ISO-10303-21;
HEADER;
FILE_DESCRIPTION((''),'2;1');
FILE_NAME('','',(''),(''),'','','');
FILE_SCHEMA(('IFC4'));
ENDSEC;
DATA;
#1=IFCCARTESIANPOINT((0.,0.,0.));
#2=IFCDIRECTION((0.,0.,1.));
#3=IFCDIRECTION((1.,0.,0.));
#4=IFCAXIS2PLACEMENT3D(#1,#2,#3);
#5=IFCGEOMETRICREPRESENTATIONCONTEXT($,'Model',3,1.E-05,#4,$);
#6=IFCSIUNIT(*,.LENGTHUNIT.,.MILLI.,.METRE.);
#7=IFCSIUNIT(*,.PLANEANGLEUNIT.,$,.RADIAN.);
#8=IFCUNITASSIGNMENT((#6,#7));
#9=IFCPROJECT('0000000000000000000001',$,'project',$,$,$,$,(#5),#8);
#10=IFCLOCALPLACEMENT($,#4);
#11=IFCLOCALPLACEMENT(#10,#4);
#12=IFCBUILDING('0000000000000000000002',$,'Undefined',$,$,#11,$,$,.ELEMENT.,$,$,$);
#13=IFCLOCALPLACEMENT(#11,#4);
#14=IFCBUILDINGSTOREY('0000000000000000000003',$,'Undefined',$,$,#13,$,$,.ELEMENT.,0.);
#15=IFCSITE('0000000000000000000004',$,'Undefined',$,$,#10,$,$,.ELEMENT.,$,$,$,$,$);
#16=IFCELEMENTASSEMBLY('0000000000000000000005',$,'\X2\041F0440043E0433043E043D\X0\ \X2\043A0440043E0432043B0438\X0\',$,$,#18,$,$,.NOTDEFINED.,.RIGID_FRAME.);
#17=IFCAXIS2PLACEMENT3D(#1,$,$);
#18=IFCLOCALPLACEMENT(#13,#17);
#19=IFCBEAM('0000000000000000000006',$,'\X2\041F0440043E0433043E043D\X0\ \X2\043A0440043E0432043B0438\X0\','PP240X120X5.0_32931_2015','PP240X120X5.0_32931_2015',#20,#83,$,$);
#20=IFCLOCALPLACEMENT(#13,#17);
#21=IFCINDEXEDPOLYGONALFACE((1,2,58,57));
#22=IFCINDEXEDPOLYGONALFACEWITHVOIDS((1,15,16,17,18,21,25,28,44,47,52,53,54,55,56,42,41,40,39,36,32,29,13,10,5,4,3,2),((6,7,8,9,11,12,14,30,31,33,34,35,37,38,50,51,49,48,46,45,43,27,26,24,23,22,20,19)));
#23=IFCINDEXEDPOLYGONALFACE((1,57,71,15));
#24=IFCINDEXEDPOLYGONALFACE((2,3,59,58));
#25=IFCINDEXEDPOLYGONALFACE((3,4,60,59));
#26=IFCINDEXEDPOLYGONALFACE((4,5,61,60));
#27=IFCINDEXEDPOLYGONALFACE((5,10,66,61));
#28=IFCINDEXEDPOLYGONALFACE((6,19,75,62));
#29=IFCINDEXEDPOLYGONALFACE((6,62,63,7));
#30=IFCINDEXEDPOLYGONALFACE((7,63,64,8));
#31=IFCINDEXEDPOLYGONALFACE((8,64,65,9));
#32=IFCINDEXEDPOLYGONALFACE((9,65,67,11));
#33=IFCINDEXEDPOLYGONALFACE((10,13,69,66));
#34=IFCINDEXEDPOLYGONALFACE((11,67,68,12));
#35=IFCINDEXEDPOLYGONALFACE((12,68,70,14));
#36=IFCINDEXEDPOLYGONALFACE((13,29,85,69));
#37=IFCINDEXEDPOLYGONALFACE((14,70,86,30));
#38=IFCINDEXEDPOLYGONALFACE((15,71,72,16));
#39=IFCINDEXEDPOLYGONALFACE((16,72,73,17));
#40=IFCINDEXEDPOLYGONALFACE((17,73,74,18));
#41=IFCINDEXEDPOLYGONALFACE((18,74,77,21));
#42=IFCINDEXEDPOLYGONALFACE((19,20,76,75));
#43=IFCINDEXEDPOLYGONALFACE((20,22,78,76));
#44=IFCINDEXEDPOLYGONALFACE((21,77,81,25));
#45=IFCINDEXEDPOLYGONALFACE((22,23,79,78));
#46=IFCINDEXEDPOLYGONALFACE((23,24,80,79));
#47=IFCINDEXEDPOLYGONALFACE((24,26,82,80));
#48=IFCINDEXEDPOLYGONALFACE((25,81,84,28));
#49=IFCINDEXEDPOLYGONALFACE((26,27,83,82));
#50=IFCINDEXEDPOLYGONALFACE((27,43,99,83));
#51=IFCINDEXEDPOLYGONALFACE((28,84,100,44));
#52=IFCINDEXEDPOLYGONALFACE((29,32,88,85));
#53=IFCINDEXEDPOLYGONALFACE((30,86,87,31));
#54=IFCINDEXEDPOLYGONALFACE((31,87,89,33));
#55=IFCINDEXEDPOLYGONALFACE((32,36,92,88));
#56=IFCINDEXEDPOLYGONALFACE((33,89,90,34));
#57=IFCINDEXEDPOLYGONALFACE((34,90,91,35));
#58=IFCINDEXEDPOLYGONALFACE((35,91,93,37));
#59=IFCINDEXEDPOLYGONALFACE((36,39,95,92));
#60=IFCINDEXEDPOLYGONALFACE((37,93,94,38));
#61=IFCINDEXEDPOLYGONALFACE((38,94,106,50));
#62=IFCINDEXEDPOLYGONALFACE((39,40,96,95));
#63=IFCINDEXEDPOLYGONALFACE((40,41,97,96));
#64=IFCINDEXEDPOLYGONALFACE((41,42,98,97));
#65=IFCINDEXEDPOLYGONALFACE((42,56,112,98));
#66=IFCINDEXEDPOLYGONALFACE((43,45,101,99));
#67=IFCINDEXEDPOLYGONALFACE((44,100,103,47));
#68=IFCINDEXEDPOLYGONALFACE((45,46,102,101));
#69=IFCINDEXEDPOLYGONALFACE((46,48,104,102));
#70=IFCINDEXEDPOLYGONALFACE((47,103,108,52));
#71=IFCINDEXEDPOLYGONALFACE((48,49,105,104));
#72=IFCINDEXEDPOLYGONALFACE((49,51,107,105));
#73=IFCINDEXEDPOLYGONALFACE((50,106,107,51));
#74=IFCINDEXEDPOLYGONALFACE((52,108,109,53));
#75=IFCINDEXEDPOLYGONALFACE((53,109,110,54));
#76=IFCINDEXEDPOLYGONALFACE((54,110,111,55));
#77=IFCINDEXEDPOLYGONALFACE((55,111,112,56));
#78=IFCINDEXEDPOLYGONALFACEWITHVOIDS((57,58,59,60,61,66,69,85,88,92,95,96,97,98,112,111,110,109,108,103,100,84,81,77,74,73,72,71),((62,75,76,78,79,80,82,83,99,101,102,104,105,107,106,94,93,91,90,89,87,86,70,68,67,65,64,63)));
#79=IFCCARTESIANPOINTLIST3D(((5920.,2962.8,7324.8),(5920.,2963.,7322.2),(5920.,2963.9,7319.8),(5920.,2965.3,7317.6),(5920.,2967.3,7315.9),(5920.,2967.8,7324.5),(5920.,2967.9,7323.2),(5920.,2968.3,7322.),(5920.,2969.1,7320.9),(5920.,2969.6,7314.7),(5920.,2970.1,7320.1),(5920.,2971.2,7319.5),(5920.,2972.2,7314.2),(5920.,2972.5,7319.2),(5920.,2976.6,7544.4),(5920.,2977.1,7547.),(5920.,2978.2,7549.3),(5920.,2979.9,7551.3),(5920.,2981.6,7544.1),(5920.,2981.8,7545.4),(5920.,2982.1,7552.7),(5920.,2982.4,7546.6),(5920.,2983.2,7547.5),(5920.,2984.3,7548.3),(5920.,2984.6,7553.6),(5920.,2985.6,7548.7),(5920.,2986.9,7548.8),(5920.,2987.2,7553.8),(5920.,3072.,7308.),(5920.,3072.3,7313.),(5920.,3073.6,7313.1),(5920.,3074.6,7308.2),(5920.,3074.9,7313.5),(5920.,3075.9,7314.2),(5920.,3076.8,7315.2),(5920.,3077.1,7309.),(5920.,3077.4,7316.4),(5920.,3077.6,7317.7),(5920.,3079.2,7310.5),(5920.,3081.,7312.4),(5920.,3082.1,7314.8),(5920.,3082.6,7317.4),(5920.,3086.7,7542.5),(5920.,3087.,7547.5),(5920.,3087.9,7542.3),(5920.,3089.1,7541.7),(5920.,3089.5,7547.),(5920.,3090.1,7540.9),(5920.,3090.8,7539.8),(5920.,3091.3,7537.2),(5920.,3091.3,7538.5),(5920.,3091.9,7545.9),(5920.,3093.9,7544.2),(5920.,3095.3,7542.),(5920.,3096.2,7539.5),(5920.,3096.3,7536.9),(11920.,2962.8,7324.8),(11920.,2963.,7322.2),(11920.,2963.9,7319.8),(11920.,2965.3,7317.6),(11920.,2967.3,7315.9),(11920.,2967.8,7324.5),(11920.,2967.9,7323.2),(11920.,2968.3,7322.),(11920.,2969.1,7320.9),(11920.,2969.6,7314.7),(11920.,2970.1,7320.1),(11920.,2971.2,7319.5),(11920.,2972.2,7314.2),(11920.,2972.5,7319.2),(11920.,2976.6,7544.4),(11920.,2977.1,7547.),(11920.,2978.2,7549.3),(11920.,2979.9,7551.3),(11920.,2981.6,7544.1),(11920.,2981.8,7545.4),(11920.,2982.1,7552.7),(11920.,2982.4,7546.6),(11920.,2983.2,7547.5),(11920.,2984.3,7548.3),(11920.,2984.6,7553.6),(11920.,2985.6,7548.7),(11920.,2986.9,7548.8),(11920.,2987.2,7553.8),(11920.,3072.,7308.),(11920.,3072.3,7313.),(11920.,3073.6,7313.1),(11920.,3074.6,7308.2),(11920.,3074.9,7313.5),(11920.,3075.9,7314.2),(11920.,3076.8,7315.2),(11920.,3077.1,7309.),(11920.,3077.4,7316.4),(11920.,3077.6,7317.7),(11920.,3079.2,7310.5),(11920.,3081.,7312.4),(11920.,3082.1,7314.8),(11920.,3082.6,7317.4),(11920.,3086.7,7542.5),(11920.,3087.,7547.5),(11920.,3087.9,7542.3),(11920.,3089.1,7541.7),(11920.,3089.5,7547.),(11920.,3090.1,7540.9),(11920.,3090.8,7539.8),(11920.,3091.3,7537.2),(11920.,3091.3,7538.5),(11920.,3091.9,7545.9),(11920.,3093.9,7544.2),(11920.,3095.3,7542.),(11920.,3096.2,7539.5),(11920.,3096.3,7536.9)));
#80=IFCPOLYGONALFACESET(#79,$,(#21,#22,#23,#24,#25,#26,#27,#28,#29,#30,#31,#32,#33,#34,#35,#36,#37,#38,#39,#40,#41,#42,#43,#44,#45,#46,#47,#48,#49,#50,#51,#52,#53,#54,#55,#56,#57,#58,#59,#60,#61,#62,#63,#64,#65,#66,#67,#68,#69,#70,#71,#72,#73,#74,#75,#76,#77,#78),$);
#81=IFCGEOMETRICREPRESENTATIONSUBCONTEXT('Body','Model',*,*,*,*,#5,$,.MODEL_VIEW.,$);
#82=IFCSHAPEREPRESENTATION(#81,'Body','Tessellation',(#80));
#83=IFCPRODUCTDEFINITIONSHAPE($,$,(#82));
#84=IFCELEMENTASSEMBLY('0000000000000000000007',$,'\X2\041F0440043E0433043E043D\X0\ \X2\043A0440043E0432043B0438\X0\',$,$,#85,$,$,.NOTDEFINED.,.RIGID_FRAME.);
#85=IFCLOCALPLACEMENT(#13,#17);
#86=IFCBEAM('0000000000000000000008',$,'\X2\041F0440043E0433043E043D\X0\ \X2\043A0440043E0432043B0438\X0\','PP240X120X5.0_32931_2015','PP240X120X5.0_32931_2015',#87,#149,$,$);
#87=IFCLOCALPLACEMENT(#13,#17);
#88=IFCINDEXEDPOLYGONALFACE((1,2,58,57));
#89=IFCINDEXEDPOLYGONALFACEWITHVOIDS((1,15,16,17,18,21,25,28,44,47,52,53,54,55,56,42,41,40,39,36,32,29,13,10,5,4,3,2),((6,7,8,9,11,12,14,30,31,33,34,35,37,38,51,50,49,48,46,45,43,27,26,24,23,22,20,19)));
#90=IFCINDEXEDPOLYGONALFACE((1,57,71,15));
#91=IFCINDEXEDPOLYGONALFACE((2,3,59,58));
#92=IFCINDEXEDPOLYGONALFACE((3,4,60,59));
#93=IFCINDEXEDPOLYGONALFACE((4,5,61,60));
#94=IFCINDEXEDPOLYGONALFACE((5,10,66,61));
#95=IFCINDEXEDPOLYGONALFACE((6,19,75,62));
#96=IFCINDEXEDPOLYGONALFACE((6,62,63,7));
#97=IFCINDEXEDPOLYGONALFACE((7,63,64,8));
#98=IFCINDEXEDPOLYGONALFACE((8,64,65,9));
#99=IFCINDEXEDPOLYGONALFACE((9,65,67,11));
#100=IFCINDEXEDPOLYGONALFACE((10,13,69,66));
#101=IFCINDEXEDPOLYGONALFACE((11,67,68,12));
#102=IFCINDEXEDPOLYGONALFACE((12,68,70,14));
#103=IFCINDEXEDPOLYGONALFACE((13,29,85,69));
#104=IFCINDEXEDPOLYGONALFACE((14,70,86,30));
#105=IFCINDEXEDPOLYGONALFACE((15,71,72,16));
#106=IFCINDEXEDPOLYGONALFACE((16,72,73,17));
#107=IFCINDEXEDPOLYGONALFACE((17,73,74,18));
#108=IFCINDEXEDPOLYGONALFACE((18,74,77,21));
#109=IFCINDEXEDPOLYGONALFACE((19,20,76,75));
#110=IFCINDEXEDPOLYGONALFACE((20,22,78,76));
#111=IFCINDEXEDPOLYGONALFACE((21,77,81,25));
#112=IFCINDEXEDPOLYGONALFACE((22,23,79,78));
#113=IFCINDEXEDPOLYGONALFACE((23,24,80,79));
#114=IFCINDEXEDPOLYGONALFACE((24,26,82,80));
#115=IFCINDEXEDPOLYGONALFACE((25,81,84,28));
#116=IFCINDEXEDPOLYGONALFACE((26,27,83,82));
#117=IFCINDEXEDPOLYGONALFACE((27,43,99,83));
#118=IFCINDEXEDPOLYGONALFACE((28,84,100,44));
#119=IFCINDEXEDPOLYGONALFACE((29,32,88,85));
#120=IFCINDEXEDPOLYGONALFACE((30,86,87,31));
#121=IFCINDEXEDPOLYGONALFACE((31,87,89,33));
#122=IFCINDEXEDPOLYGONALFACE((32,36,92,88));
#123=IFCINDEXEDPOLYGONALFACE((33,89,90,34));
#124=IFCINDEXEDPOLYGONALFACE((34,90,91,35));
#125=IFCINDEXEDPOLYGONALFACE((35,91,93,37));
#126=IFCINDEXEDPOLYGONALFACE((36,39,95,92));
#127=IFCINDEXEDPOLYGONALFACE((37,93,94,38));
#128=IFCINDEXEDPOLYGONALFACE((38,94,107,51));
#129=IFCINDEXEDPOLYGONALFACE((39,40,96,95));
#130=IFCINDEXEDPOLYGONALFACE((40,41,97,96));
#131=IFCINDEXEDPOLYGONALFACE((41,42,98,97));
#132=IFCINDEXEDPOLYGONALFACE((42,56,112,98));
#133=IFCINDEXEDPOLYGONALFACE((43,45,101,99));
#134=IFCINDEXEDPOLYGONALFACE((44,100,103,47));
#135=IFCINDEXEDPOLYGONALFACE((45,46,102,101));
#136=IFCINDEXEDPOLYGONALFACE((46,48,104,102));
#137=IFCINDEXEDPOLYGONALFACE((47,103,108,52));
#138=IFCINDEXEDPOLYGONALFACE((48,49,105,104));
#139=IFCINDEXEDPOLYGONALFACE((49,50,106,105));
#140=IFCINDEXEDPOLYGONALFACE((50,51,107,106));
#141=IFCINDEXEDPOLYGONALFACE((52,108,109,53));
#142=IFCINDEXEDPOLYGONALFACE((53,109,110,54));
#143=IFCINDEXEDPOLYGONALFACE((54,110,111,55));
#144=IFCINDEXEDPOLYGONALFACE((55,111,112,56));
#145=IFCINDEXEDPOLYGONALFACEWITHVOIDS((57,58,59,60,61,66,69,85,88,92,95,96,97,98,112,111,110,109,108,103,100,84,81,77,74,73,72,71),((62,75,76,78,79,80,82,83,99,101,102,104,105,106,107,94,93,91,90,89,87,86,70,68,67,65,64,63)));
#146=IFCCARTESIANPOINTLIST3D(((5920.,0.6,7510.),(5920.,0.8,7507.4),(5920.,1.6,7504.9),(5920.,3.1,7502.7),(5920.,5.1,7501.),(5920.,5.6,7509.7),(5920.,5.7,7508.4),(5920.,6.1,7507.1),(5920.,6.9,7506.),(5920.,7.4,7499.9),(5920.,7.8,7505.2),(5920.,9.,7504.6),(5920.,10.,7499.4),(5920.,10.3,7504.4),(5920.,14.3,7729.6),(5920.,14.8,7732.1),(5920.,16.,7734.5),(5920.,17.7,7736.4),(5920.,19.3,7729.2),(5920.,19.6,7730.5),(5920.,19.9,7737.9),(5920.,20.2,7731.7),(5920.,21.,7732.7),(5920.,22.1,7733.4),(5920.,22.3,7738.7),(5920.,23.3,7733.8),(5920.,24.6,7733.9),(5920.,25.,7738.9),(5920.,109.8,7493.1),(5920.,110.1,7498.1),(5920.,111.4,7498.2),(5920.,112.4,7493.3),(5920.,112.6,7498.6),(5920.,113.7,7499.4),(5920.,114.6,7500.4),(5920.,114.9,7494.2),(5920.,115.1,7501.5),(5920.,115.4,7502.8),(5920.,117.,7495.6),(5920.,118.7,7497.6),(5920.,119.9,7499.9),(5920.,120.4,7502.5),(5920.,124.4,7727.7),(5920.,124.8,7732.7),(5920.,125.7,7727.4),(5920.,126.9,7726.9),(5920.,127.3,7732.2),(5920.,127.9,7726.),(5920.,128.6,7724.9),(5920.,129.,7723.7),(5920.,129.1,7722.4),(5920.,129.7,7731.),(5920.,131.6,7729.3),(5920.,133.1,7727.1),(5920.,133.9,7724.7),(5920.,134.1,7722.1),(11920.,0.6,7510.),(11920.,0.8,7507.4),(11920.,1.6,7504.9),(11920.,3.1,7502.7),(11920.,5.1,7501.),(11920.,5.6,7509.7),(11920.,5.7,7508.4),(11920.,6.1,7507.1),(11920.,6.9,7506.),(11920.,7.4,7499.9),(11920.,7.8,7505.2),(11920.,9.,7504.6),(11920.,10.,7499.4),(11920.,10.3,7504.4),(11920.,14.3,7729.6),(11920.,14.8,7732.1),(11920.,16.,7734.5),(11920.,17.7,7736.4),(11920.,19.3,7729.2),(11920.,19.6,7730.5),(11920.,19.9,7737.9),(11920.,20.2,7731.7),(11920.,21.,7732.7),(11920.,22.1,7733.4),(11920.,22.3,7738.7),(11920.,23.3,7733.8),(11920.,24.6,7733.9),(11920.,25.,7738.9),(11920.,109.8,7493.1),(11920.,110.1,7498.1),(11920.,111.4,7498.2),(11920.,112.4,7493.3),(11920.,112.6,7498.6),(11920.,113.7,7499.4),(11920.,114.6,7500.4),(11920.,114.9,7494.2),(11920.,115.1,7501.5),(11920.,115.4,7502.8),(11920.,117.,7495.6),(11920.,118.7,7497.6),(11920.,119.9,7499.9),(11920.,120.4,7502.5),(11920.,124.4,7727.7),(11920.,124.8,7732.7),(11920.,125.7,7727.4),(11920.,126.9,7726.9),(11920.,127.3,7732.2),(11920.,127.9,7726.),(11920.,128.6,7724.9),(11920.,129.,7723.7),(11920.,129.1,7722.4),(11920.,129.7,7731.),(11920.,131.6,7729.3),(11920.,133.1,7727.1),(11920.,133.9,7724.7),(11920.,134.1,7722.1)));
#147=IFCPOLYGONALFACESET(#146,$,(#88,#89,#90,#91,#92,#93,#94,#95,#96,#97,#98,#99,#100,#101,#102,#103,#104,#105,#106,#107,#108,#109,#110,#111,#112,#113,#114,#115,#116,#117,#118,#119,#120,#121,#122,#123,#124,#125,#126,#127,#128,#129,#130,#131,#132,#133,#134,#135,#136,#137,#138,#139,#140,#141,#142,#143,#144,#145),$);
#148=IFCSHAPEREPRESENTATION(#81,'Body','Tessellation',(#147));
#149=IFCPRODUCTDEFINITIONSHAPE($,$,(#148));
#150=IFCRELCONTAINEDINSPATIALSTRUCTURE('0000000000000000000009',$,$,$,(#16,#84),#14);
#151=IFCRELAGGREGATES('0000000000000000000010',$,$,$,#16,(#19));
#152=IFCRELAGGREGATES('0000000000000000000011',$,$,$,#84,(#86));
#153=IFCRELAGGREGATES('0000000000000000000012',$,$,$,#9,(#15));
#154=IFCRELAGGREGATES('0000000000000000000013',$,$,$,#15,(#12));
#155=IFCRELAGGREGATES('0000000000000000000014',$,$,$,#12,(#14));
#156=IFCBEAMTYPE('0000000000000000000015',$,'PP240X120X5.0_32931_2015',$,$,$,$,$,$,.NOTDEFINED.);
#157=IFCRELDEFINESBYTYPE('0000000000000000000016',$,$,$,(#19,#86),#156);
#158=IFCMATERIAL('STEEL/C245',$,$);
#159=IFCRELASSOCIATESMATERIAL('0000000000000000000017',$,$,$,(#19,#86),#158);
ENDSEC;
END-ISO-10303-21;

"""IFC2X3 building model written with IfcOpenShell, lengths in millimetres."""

from ifc_helpers import new_model, si_unit, frame, origin_with_axes, origin_2d_with_axis, place, context, subcontext, project, spatial, hollow_rectangle, extrude, material, type_object, element, aggregate, save


model = new_model("IFC2X3")

# Units and contexts
model_context = context("Model", 3, precision=1e-05, world=origin_with_axes())
body_context = subcontext(model_context, "Body", "Model", "MODEL_VIEW")
ifc_project = project(units=[si_unit("LENGTHUNIT", "METRE", prefix="MILLI"), si_unit("PLANEANGLEUNIT", "RADIAN")], contexts=[model_context])

# Site, building, storey
site_placement = place(None, origin_with_axes())
site = spatial("IfcSite", under=ifc_project, at=site_placement, Name="Undefined", CompositionType="ELEMENT")
building_placement = place(site_placement, origin_with_axes())
building = spatial("IfcBuilding", under=site, at=building_placement, Name="Undefined", CompositionType="ELEMENT")
storey_placement = place(building_placement, origin_with_axes())
storey = spatial("IfcBuildingStorey", under=building, at=storey_placement, Name="Undefined", CompositionType="ELEMENT", Elevation=0.0)

# Shared definitions
ifc_material = material(Name="STEEL/C245")

# Element assemblies, beams
beam_type_1 = type_object("IfcBeamType", Name="PP240X120X5.0_32931_2015", PredefinedType="NOTDEFINED")
assembly_1_placement = place(storey_placement, origin_with_axes())
assembly_1 = element("IfcElementAssembly", 1, at=assembly_1_placement, inside=storey, Name="Прогон кровли", AssemblyPlace="NOTDEFINED", PredefinedType="RIGID_FRAME")
beam_1_placement = place(assembly_1_placement, frame((11920.0, 3029.6, 7430.9), z_axis=(0.0, 0.062378, 0.998053), x_axis=(-1.0, 0.0, 0.0)))
beam_1 = element("IfcBeam", 2, at=beam_1_placement, type_object=beam_type_1, material=ifc_material, Name="Прогон кровли", Description="PP240X120X5.0_32931_2015", ObjectType="PP240X120X5.0_32931_2015", context=body_context, shape_type="SweptSolid", body=[
    extrude(hollow_rectangle(XDim=120.0, YDim=240.0, WallThickness=5.0, InnerFilletRadius=5.0, OuterFilletRadius=10.0, at=origin_2d_with_axis()), frame((6000.0, 0.0, 0.0), z_axis=(-1.0, 0.0, 0.0), x_axis=(0.0, -1.0, 0.0)), (0.0, 0.0, 1.0), 6000.0),
])
aggregate(assembly_1, [beam_1])
assembly_2_placement = place(storey_placement, origin_with_axes())
assembly_2 = element("IfcElementAssembly", 3, at=assembly_2_placement, inside=storey, Name="Прогон кровли", AssemblyPlace="NOTDEFINED", PredefinedType="RIGID_FRAME")
beam_2_placement = place(assembly_2_placement, frame((11920.0, 67.4, 7616.0), z_axis=(0.0, 0.062378, 0.998053), x_axis=(-1.0, 0.0, 0.0)))
beam_2 = element("IfcBeam", 4, at=beam_2_placement, type_object=beam_type_1, material=ifc_material, Name="Прогон кровли", Description="PP240X120X5.0_32931_2015", ObjectType="PP240X120X5.0_32931_2015", context=body_context, shape_type="SweptSolid", body=[
    extrude(hollow_rectangle(XDim=120.0, YDim=240.0, WallThickness=5.0, InnerFilletRadius=5.0, OuterFilletRadius=10.0, at=origin_2d_with_axis()), frame((6000.0, 0.0, 0.0), z_axis=(-1.0, 0.0, 0.0), x_axis=(0.0, -1.0, 0.0)), (0.0, 0.0, 1.0), 6000.0),
])
aggregate(assembly_2, [beam_2])

save(model, "model.ifc")
